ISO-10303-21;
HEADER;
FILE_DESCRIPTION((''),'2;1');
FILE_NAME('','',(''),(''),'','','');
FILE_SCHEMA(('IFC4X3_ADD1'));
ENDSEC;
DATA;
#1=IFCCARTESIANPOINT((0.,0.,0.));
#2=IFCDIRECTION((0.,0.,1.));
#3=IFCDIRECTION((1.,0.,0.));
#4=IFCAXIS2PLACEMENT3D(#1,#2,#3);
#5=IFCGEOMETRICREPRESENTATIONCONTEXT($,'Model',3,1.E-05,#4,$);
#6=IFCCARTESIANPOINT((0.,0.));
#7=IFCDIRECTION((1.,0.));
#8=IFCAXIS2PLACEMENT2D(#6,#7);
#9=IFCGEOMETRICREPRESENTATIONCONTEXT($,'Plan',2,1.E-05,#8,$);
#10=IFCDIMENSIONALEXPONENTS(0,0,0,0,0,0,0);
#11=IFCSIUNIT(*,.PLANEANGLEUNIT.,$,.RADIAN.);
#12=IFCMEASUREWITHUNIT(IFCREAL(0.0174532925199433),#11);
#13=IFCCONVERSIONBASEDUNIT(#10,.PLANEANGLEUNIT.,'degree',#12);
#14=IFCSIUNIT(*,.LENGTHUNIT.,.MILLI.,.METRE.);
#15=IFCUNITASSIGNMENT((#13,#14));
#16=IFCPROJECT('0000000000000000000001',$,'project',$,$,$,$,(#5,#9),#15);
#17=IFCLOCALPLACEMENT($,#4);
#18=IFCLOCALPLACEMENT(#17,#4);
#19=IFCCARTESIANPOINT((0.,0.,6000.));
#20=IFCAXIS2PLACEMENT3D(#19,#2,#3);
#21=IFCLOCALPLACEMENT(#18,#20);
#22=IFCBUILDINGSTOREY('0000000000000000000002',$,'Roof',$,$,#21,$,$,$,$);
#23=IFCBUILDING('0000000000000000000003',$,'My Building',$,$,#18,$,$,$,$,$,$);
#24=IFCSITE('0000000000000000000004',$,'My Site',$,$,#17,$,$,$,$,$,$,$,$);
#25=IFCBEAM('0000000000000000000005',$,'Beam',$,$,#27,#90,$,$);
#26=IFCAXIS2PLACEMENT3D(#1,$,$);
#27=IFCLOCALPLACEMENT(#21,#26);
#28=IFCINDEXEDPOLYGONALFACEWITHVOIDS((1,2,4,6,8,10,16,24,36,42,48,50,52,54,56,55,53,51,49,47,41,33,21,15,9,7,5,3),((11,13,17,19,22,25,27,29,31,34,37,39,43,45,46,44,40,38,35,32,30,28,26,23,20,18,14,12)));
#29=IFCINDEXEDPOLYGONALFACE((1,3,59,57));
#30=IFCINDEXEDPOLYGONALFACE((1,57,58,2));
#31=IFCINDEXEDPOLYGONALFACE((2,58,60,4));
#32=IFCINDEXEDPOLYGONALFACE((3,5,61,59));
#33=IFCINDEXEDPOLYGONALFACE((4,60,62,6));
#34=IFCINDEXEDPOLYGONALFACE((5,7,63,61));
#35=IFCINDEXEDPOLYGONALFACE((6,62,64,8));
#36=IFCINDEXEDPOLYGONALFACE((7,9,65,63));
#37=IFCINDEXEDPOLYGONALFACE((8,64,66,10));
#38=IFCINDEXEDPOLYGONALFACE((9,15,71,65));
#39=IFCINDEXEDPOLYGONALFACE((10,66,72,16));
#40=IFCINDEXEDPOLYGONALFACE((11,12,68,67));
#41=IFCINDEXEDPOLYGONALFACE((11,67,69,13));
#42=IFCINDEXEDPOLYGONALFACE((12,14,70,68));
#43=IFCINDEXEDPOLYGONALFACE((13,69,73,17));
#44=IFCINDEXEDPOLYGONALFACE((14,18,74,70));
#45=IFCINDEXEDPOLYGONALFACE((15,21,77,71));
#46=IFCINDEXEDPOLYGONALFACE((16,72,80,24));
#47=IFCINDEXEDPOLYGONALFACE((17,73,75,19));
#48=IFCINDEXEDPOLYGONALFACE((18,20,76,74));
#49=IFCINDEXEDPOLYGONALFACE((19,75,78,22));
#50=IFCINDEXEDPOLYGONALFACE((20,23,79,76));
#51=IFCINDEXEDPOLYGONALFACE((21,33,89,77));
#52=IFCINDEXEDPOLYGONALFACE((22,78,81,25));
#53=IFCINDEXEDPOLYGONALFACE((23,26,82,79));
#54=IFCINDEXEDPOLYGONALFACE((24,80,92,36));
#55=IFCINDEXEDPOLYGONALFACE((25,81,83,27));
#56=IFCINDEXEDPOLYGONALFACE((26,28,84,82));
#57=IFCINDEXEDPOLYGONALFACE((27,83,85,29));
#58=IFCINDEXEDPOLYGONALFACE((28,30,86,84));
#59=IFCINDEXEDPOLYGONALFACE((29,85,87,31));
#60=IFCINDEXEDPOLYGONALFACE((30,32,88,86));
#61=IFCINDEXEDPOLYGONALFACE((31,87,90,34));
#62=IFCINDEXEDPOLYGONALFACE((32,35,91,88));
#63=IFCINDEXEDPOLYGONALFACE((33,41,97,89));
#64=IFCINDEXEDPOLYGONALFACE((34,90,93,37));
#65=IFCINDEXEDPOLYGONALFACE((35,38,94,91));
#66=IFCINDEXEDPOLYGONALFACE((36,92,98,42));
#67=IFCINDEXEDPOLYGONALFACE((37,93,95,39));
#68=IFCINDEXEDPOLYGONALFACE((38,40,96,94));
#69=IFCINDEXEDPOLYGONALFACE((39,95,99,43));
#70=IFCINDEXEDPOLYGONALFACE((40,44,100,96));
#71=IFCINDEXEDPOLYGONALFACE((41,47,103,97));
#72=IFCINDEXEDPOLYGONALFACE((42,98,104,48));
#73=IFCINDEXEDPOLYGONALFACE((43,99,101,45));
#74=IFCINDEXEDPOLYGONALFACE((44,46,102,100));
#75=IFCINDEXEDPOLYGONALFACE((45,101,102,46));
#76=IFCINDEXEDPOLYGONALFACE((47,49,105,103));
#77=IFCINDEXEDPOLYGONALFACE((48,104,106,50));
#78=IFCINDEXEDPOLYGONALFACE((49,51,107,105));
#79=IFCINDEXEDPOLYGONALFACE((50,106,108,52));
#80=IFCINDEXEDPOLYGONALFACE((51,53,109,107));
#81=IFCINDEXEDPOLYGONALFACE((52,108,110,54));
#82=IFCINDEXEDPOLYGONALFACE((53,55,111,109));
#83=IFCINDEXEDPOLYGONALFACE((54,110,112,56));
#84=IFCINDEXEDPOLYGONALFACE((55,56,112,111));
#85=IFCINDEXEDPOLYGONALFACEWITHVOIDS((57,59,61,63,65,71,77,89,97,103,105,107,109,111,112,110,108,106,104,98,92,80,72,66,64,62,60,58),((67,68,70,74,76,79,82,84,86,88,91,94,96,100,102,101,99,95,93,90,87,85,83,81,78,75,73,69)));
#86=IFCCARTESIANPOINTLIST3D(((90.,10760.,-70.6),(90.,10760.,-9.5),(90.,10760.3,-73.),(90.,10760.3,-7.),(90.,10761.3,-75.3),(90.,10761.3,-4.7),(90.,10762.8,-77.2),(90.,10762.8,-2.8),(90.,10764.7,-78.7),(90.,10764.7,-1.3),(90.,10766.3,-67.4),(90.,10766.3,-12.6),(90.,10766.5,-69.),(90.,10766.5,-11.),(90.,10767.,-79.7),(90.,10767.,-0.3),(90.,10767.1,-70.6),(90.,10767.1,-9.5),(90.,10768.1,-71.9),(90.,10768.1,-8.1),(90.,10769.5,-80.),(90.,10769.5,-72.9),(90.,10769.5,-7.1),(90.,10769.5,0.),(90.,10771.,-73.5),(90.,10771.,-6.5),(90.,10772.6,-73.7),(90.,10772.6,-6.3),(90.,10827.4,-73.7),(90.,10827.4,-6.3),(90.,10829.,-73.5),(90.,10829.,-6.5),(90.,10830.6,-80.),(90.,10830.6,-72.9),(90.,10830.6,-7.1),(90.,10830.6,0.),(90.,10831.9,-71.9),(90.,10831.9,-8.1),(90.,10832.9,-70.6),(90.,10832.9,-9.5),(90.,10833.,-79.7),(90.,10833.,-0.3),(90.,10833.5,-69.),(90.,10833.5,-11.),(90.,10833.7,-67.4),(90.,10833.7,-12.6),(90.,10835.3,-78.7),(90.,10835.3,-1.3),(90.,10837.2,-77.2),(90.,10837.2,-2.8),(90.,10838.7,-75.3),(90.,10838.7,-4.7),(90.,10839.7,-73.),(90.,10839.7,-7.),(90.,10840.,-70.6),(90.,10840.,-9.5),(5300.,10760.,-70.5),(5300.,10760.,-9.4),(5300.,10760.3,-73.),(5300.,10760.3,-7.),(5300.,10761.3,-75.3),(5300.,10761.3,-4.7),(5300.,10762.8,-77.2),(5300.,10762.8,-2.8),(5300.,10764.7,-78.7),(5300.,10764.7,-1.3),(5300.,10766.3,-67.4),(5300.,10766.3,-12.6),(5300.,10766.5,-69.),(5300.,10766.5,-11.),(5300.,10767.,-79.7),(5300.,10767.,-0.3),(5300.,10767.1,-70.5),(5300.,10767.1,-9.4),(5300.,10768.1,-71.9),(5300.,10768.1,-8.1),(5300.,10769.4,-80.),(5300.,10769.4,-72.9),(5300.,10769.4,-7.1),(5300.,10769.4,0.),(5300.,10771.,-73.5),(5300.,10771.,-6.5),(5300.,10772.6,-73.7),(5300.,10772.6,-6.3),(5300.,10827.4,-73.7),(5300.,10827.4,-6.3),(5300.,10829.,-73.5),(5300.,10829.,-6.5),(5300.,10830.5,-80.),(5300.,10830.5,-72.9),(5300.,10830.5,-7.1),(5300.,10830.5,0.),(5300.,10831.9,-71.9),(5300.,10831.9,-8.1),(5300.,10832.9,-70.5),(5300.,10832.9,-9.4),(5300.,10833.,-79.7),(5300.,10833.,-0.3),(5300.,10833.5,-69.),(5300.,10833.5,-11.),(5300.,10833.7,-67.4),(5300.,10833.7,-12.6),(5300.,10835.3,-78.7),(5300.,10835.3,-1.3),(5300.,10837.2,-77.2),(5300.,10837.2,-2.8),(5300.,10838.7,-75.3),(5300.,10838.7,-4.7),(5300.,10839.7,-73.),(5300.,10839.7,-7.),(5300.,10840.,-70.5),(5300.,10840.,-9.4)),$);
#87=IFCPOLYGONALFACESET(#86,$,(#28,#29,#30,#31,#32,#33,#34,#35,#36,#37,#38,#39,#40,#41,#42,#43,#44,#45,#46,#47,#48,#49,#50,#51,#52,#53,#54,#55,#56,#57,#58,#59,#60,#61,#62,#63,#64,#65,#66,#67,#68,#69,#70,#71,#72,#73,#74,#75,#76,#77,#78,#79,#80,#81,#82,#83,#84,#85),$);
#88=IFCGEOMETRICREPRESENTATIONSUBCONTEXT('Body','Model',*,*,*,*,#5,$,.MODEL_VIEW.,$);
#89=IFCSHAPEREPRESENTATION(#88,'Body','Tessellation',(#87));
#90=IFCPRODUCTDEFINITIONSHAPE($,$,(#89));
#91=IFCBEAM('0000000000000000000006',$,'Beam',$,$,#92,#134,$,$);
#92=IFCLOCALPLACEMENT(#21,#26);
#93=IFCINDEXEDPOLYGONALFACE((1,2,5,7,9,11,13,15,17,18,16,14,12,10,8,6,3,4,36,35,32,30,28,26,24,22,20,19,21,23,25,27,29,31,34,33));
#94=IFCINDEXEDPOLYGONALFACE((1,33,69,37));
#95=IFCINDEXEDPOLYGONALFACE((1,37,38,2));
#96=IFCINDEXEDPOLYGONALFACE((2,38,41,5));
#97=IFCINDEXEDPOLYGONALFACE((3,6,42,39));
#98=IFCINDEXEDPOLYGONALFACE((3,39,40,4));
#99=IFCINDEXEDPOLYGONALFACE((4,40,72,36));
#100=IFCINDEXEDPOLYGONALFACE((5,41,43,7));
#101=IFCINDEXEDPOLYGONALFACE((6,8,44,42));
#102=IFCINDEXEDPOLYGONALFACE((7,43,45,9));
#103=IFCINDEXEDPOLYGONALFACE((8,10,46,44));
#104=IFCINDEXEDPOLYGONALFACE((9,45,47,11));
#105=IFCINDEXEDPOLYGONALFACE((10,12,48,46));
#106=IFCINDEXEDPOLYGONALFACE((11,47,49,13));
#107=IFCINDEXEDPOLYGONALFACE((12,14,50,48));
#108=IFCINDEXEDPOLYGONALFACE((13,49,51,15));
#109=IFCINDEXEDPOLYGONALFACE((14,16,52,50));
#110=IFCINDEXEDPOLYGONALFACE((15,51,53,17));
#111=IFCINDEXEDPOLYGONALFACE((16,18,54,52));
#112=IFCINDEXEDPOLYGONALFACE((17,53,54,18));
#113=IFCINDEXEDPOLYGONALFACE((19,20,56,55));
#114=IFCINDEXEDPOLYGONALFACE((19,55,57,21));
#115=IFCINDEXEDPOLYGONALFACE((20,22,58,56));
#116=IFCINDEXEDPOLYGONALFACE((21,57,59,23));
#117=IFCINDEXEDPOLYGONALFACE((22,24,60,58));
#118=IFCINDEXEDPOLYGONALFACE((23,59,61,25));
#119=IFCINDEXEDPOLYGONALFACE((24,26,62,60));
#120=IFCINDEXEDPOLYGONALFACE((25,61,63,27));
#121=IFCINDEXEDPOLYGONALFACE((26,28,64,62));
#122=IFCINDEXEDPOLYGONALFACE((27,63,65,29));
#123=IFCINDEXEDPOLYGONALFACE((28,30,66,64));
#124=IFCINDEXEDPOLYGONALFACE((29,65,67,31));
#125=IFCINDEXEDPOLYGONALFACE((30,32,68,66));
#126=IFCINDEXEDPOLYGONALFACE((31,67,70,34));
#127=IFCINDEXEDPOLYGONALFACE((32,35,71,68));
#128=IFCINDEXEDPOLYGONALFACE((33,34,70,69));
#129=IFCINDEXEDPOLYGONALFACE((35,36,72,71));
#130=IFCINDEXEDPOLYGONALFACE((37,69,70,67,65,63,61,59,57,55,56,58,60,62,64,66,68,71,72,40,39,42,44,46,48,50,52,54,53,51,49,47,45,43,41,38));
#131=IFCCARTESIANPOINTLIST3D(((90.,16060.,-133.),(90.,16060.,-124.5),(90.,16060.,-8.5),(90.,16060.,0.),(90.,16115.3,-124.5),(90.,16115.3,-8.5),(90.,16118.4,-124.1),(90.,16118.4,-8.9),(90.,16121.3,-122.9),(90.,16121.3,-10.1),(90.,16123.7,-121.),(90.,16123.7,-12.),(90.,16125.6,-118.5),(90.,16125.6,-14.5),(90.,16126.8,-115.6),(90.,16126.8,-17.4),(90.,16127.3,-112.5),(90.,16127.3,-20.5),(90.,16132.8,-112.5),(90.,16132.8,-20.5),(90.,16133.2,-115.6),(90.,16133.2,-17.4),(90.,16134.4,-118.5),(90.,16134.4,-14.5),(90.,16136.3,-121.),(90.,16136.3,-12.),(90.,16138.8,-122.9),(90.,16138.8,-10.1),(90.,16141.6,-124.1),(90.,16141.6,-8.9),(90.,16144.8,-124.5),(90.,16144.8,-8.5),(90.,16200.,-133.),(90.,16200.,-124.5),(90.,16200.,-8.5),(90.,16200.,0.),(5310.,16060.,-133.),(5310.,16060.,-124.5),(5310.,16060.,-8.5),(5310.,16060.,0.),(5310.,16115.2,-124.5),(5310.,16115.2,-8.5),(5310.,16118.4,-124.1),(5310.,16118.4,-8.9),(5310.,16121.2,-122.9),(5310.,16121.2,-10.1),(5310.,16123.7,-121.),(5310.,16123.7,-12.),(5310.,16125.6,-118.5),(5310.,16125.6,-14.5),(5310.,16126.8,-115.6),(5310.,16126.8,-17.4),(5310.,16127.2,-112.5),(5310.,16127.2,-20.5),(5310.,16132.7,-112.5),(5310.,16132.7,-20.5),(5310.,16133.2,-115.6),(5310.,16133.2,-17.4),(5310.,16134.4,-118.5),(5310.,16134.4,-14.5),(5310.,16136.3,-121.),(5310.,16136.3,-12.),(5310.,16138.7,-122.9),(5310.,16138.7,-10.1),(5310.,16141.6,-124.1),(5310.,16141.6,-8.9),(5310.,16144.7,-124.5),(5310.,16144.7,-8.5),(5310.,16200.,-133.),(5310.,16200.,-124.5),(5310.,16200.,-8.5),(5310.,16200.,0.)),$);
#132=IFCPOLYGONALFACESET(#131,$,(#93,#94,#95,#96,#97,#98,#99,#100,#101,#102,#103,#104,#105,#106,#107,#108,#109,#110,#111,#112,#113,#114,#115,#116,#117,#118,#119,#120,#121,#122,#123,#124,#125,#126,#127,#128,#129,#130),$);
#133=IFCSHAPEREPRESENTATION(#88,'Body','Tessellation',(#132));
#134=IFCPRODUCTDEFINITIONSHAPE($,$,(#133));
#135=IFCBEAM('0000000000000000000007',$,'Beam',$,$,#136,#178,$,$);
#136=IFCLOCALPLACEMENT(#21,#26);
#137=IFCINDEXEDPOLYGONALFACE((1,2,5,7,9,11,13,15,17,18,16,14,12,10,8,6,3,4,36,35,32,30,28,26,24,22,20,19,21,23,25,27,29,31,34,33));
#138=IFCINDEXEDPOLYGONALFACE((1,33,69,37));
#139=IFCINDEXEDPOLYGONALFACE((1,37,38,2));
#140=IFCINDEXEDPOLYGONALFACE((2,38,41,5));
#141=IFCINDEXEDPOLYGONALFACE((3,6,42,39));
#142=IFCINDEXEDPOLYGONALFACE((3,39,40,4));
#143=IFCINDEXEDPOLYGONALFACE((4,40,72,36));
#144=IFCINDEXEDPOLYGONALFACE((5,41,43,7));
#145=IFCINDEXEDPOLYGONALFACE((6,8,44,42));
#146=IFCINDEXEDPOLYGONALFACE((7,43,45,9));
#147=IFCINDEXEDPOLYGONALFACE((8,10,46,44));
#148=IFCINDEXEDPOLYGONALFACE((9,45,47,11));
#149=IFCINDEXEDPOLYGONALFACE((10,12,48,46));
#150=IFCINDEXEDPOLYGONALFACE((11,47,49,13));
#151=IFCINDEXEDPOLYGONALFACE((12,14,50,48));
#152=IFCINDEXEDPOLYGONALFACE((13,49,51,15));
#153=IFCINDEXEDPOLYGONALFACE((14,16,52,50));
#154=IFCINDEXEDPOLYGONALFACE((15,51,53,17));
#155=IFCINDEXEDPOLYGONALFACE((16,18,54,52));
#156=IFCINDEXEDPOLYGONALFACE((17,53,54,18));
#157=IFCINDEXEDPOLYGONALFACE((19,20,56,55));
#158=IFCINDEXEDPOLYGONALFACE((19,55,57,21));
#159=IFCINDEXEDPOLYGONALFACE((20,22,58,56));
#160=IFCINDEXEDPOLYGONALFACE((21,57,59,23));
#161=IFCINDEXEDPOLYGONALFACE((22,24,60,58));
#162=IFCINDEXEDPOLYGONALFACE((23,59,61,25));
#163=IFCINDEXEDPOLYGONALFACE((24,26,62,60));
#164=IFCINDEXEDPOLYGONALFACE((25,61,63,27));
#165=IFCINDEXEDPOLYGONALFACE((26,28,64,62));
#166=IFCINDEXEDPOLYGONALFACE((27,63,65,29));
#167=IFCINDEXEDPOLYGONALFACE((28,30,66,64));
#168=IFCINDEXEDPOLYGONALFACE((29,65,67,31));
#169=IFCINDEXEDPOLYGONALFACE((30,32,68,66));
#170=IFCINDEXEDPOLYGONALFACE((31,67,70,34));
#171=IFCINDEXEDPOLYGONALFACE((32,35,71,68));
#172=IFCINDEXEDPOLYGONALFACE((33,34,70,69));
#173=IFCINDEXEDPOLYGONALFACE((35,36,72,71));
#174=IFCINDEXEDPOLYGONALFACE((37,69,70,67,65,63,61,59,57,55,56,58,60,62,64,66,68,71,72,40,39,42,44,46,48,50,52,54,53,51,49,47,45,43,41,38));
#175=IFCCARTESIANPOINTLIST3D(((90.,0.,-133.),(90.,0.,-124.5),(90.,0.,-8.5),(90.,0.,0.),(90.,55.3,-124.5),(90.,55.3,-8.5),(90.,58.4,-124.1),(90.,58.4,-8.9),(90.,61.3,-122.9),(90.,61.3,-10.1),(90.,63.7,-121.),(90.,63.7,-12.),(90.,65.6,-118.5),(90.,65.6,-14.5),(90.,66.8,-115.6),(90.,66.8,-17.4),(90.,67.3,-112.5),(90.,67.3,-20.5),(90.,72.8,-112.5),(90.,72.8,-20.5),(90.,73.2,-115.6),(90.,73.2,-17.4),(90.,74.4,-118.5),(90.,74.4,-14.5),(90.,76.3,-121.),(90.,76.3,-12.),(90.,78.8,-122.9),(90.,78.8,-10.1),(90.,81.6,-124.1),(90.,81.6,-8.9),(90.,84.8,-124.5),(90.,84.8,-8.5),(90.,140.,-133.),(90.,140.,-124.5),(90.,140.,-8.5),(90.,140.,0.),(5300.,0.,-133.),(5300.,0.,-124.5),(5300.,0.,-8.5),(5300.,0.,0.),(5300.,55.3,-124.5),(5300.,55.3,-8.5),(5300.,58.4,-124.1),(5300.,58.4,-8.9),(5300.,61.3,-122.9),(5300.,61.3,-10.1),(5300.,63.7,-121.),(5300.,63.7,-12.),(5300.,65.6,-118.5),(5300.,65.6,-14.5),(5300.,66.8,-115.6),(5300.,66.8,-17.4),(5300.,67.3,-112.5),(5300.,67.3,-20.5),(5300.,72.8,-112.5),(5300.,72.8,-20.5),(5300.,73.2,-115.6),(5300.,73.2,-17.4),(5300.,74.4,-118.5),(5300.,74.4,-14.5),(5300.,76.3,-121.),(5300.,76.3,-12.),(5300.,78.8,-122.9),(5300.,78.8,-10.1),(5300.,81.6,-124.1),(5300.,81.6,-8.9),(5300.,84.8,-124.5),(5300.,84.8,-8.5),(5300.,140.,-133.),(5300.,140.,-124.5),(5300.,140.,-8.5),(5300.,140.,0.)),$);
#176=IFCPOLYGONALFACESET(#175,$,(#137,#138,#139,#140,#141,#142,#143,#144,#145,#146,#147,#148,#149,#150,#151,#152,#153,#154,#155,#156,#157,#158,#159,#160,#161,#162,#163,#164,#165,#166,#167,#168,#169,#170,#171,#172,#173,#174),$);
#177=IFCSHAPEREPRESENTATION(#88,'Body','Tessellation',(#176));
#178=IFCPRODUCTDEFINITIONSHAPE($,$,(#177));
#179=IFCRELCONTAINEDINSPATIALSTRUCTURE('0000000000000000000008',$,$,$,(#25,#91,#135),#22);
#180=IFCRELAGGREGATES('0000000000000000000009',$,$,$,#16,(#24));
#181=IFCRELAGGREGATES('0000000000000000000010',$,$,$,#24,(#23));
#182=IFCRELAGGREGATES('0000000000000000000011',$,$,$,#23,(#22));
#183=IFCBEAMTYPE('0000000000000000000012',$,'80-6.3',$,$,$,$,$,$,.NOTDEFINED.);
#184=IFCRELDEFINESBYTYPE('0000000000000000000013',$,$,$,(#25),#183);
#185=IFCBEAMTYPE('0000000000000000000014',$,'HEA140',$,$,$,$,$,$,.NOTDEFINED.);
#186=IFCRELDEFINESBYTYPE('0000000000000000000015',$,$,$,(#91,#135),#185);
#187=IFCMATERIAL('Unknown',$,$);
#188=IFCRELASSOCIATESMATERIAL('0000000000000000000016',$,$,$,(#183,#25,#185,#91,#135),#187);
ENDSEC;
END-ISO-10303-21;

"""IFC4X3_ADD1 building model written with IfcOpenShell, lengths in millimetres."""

from ifc_helpers import new_model, entity, si_unit, converted_unit, frame, origin_with_axes, origin_2d_with_axis, place, context, subcontext, project, spatial, hollow_rectangle, i_section, extrude, material, material_profile, profile_set, profile_usage, type_object, element, save


model = new_model("IFC4X3_ADD1")

# Units and contexts
model_context = context("Model", 3, precision=1e-05, world=origin_with_axes())
plan_context = context("Plan", 2, precision=1e-05, world=origin_2d_with_axis())
body_context = subcontext(model_context, "Body", "Model", "MODEL_VIEW")
ifc_project = project(units=[converted_unit("PLANEANGLEUNIT", "degree", entity("IfcReal", 0.0174532925199433), si_unit("PLANEANGLEUNIT", "RADIAN"), dimensions=[0, 0, 0, 0, 0, 0, 0]), si_unit("LENGTHUNIT", "METRE", prefix="MILLI")], contexts=[model_context, plan_context])

# Site, building, storey
site_placement = place(None, origin_with_axes())
site = spatial("IfcSite", under=ifc_project, at=site_placement, Name="My Site")
building_placement = place(site_placement, origin_with_axes())
building = spatial("IfcBuilding", under=site, at=building_placement, Name="My Building")
storey_placement = place(building_placement, frame((0.0, 0.0, 6000.0), z_axis=(0.0, 0.0, 1.0), x_axis=(1.0, 0.0, 0.0)))
storey = spatial("IfcBuildingStorey", under=building, at=storey_placement, Name="Roof")

# Beams
ifc_material = material(Name="Unknown")
ifc_material_profile_1 = material_profile(ifc_material, hollow_rectangle(XDim=80.0, YDim=80.0, WallThickness=6.3, InnerFilletRadius=6.3, OuterFilletRadius=9.4))
ifc_profile_set_1 = profile_set([ifc_material_profile_1])
beam_type_1 = type_object("IfcBeamType", Name="80-6.3", PredefinedType="NOTDEFINED", material=ifc_profile_set_1)
ifc_profile_usage_1 = profile_usage(ifc_profile_set_1, cardinal=8)
beam_1_placement = place(storey_placement, frame((90.0, 10800.0, 0.0), z_axis=(1.0, 0.0, 0.0), x_axis=(0.0, 1.0, 0.0)))
element("IfcBeam", 1, at=beam_1_placement, inside=storey, type_object=beam_type_1, material=ifc_profile_usage_1, Name="Beam", context=body_context, shape_type="SweptSolid", body=[
    extrude(hollow_rectangle(XDim=80.0, YDim=80.0, WallThickness=6.3, InnerFilletRadius=6.3, OuterFilletRadius=9.4), frame((0.0, -40.0, 0.0), z_axis=(0.0, 0.0, 1.0), x_axis=(1.0, 0.0, 0.0)), (0.0, 0.0, 1.0), 5210.0),
])
ifc_material_profile_2 = material_profile(ifc_material, i_section(OverallWidth=140.0, OverallDepth=133.0, WebThickness=5.5, FlangeThickness=8.5, FilletRadius=12.0))
ifc_profile_set_2 = profile_set([ifc_material_profile_2])
ifc_profile_usage_2 = profile_usage(ifc_profile_set_2, cardinal=7)
beam_type_2 = type_object("IfcBeamType", Name="HEA140", PredefinedType="NOTDEFINED", material=ifc_profile_set_2)
beam_2_placement = place(storey_placement, frame((90.0, 16200.0, 0.0), z_axis=(1.0, 0.0, 0.0), x_axis=(0.0, 1.0, 0.0)))
element("IfcBeam", 2, at=beam_2_placement, inside=storey, type_object=beam_type_2, material=ifc_profile_usage_2, Name="Beam", context=body_context, shape_type="SweptSolid", body=[
    extrude(i_section(OverallWidth=140.0, OverallDepth=133.0, WebThickness=5.5, FlangeThickness=8.5, FilletRadius=12.0), frame((-70.0, -66.5, 0.0), z_axis=(0.0, 0.0, 1.0), x_axis=(1.0, 0.0, 0.0)), (0.0, 0.0, 1.0), 5220.0),
])
ifc_profile_usage_3 = profile_usage(ifc_profile_set_2, cardinal=7)
beam_3_placement = place(storey_placement, frame((5300.0, 0.0, 0.0), z_axis=(-1.0, 0.0, 0.0), x_axis=(0.0, -1.0, 0.0)))
element("IfcBeam", 3, at=beam_3_placement, inside=storey, type_object=beam_type_2, material=ifc_profile_usage_3, Name="Beam", context=body_context, shape_type="SweptSolid", body=[
    extrude(i_section(OverallWidth=140.0, OverallDepth=133.0, WebThickness=5.5, FlangeThickness=8.5, FilletRadius=12.0), frame((-70.0, -66.5, 0.0), z_axis=(0.0, 0.0, 1.0), x_axis=(1.0, 0.0, 0.0)), (0.0, 0.0, 1.0), 5210.0),
])

save(model, "model.ifc")
